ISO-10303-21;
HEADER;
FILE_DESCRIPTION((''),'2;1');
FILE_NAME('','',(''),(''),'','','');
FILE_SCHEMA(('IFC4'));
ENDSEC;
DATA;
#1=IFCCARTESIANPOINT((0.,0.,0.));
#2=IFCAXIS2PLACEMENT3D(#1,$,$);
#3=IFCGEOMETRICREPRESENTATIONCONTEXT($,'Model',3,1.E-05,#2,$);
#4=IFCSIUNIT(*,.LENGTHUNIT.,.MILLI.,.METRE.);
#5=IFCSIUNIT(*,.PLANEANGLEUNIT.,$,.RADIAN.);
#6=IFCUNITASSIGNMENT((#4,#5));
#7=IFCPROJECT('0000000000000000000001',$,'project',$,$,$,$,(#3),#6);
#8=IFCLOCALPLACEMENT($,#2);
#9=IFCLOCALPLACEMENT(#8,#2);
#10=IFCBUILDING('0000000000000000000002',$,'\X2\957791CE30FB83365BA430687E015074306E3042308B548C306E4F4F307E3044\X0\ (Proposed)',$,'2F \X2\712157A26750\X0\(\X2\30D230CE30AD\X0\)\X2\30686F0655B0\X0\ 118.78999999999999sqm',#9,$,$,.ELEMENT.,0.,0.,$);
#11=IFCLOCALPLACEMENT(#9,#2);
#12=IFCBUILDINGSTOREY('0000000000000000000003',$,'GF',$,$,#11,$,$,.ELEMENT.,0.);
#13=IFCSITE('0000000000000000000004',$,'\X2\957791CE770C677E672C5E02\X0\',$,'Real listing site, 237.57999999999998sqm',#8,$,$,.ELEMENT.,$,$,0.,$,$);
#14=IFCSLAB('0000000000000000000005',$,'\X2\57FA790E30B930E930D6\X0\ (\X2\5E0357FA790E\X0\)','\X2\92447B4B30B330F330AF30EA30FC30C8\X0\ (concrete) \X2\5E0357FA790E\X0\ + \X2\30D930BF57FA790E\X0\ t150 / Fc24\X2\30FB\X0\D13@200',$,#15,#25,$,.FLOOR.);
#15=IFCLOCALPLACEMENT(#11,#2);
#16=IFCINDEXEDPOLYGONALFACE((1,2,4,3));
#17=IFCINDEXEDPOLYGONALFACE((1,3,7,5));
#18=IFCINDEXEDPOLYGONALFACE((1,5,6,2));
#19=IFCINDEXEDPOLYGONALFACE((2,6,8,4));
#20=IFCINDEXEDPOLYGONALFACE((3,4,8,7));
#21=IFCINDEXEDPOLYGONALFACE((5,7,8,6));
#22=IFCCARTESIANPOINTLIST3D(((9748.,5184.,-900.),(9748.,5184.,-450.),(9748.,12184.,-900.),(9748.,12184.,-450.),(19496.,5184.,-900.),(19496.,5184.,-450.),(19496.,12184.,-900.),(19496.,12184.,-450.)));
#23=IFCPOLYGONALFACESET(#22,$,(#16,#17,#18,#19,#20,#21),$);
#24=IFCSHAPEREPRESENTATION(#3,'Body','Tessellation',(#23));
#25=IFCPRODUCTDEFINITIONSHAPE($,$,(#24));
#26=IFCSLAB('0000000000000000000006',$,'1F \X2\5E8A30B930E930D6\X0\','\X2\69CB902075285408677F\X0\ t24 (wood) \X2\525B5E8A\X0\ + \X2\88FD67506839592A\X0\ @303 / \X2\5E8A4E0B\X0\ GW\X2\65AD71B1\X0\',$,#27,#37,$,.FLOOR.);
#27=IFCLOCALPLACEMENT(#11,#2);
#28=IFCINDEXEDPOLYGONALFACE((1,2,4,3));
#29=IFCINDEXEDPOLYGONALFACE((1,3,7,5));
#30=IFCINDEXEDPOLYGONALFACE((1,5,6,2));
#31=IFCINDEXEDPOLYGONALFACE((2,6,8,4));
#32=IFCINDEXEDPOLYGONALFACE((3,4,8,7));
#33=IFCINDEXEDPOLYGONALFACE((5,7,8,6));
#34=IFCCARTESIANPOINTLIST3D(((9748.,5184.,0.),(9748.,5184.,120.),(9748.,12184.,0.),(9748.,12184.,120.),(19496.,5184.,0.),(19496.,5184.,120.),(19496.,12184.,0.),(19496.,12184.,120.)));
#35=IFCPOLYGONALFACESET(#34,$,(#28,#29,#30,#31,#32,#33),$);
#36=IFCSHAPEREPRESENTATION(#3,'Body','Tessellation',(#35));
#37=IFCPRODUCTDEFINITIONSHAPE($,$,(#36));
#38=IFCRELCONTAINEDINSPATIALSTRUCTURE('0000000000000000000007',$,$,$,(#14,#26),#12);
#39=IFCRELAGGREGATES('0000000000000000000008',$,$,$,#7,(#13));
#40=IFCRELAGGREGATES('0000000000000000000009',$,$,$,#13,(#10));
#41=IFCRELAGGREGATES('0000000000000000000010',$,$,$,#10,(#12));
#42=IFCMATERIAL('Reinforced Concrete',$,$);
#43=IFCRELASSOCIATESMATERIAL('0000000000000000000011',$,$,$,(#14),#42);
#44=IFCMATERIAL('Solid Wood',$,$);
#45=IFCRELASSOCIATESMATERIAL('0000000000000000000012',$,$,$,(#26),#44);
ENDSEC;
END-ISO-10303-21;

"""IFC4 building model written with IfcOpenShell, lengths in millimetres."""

from ifc_helpers import new_model, si_unit, frame, frame_2d, origin, place, context, project, spatial, rectangle, extrude, material, element, save


model = new_model("IFC4")

# Units and contexts
model_context = context("Model", 3, precision=1e-05, world=origin())
ifc_project = project(units=[si_unit("LENGTHUNIT", "METRE", prefix="MILLI"), si_unit("PLANEANGLEUNIT", "RADIAN")], contexts=[model_context])

# Site, building, storey
site_placement = place(None, origin())
site = spatial("IfcSite", under=ifc_project, at=site_placement, Name="長野県松本市", ObjectType="Real listing site, 237.57999999999998sqm", CompositionType="ELEMENT", RefElevation=0.0)
building_placement = place(site_placement, origin())
building = spatial("IfcBuilding", under=site, at=building_placement, Name="長野・茶室と縁側のある和の住まい (Proposed)", ObjectType="2F 無垢材(ヒノキ)と漆喰 118.78999999999999sqm", CompositionType="ELEMENT", ElevationOfRefHeight=0.0, ElevationOfTerrain=0.0)
storey_placement = place(building_placement, origin())
storey = spatial("IfcBuildingStorey", under=building, at=storey_placement, Name="GF", CompositionType="ELEMENT", Elevation=0.0)

# Slabs
ifc_material_1 = material(Name="Reinforced Concrete")
slab_1_placement = place(storey_placement, frame((4874.0, 2592.0, -450.0)))
element("IfcSlab", 1, at=slab_1_placement, inside=storey, material=ifc_material_1, Name="基礎スラブ (布基礎)", Description="鉄筋コンクリート (concrete) 布基礎 + ベタ基礎 t150 / Fc24・D13@200", PredefinedType="FLOOR", context=model_context, shape_type="SweptSolid", body=[
    extrude(rectangle(XDim=9748.0, YDim=7000.0, at=frame_2d((4874.0, 3500.0))), frame((4874.0, 2592.0, -450.0)), (0.0, 0.0, 1.0), 450.0),
])
ifc_material_2 = material(Name="Solid Wood")
slab_2_placement = place(storey_placement, frame((4874.0, 2592.0, 0.0)))
element("IfcSlab", 2, at=slab_2_placement, inside=storey, material=ifc_material_2, Name="1F 床スラブ", Description="構造用合板 t24 (wood) 剛床 + 製材根太 @303 / 床下 GW断熱", PredefinedType="FLOOR", context=model_context, shape_type="SweptSolid", body=[
    extrude(rectangle(XDim=9748.0, YDim=7000.0, at=frame_2d((4874.0, 3500.0))), frame((4874.0, 2592.0, 0.0)), (0.0, 0.0, 1.0), 120.0),
])

save(model, "model.ifc")
